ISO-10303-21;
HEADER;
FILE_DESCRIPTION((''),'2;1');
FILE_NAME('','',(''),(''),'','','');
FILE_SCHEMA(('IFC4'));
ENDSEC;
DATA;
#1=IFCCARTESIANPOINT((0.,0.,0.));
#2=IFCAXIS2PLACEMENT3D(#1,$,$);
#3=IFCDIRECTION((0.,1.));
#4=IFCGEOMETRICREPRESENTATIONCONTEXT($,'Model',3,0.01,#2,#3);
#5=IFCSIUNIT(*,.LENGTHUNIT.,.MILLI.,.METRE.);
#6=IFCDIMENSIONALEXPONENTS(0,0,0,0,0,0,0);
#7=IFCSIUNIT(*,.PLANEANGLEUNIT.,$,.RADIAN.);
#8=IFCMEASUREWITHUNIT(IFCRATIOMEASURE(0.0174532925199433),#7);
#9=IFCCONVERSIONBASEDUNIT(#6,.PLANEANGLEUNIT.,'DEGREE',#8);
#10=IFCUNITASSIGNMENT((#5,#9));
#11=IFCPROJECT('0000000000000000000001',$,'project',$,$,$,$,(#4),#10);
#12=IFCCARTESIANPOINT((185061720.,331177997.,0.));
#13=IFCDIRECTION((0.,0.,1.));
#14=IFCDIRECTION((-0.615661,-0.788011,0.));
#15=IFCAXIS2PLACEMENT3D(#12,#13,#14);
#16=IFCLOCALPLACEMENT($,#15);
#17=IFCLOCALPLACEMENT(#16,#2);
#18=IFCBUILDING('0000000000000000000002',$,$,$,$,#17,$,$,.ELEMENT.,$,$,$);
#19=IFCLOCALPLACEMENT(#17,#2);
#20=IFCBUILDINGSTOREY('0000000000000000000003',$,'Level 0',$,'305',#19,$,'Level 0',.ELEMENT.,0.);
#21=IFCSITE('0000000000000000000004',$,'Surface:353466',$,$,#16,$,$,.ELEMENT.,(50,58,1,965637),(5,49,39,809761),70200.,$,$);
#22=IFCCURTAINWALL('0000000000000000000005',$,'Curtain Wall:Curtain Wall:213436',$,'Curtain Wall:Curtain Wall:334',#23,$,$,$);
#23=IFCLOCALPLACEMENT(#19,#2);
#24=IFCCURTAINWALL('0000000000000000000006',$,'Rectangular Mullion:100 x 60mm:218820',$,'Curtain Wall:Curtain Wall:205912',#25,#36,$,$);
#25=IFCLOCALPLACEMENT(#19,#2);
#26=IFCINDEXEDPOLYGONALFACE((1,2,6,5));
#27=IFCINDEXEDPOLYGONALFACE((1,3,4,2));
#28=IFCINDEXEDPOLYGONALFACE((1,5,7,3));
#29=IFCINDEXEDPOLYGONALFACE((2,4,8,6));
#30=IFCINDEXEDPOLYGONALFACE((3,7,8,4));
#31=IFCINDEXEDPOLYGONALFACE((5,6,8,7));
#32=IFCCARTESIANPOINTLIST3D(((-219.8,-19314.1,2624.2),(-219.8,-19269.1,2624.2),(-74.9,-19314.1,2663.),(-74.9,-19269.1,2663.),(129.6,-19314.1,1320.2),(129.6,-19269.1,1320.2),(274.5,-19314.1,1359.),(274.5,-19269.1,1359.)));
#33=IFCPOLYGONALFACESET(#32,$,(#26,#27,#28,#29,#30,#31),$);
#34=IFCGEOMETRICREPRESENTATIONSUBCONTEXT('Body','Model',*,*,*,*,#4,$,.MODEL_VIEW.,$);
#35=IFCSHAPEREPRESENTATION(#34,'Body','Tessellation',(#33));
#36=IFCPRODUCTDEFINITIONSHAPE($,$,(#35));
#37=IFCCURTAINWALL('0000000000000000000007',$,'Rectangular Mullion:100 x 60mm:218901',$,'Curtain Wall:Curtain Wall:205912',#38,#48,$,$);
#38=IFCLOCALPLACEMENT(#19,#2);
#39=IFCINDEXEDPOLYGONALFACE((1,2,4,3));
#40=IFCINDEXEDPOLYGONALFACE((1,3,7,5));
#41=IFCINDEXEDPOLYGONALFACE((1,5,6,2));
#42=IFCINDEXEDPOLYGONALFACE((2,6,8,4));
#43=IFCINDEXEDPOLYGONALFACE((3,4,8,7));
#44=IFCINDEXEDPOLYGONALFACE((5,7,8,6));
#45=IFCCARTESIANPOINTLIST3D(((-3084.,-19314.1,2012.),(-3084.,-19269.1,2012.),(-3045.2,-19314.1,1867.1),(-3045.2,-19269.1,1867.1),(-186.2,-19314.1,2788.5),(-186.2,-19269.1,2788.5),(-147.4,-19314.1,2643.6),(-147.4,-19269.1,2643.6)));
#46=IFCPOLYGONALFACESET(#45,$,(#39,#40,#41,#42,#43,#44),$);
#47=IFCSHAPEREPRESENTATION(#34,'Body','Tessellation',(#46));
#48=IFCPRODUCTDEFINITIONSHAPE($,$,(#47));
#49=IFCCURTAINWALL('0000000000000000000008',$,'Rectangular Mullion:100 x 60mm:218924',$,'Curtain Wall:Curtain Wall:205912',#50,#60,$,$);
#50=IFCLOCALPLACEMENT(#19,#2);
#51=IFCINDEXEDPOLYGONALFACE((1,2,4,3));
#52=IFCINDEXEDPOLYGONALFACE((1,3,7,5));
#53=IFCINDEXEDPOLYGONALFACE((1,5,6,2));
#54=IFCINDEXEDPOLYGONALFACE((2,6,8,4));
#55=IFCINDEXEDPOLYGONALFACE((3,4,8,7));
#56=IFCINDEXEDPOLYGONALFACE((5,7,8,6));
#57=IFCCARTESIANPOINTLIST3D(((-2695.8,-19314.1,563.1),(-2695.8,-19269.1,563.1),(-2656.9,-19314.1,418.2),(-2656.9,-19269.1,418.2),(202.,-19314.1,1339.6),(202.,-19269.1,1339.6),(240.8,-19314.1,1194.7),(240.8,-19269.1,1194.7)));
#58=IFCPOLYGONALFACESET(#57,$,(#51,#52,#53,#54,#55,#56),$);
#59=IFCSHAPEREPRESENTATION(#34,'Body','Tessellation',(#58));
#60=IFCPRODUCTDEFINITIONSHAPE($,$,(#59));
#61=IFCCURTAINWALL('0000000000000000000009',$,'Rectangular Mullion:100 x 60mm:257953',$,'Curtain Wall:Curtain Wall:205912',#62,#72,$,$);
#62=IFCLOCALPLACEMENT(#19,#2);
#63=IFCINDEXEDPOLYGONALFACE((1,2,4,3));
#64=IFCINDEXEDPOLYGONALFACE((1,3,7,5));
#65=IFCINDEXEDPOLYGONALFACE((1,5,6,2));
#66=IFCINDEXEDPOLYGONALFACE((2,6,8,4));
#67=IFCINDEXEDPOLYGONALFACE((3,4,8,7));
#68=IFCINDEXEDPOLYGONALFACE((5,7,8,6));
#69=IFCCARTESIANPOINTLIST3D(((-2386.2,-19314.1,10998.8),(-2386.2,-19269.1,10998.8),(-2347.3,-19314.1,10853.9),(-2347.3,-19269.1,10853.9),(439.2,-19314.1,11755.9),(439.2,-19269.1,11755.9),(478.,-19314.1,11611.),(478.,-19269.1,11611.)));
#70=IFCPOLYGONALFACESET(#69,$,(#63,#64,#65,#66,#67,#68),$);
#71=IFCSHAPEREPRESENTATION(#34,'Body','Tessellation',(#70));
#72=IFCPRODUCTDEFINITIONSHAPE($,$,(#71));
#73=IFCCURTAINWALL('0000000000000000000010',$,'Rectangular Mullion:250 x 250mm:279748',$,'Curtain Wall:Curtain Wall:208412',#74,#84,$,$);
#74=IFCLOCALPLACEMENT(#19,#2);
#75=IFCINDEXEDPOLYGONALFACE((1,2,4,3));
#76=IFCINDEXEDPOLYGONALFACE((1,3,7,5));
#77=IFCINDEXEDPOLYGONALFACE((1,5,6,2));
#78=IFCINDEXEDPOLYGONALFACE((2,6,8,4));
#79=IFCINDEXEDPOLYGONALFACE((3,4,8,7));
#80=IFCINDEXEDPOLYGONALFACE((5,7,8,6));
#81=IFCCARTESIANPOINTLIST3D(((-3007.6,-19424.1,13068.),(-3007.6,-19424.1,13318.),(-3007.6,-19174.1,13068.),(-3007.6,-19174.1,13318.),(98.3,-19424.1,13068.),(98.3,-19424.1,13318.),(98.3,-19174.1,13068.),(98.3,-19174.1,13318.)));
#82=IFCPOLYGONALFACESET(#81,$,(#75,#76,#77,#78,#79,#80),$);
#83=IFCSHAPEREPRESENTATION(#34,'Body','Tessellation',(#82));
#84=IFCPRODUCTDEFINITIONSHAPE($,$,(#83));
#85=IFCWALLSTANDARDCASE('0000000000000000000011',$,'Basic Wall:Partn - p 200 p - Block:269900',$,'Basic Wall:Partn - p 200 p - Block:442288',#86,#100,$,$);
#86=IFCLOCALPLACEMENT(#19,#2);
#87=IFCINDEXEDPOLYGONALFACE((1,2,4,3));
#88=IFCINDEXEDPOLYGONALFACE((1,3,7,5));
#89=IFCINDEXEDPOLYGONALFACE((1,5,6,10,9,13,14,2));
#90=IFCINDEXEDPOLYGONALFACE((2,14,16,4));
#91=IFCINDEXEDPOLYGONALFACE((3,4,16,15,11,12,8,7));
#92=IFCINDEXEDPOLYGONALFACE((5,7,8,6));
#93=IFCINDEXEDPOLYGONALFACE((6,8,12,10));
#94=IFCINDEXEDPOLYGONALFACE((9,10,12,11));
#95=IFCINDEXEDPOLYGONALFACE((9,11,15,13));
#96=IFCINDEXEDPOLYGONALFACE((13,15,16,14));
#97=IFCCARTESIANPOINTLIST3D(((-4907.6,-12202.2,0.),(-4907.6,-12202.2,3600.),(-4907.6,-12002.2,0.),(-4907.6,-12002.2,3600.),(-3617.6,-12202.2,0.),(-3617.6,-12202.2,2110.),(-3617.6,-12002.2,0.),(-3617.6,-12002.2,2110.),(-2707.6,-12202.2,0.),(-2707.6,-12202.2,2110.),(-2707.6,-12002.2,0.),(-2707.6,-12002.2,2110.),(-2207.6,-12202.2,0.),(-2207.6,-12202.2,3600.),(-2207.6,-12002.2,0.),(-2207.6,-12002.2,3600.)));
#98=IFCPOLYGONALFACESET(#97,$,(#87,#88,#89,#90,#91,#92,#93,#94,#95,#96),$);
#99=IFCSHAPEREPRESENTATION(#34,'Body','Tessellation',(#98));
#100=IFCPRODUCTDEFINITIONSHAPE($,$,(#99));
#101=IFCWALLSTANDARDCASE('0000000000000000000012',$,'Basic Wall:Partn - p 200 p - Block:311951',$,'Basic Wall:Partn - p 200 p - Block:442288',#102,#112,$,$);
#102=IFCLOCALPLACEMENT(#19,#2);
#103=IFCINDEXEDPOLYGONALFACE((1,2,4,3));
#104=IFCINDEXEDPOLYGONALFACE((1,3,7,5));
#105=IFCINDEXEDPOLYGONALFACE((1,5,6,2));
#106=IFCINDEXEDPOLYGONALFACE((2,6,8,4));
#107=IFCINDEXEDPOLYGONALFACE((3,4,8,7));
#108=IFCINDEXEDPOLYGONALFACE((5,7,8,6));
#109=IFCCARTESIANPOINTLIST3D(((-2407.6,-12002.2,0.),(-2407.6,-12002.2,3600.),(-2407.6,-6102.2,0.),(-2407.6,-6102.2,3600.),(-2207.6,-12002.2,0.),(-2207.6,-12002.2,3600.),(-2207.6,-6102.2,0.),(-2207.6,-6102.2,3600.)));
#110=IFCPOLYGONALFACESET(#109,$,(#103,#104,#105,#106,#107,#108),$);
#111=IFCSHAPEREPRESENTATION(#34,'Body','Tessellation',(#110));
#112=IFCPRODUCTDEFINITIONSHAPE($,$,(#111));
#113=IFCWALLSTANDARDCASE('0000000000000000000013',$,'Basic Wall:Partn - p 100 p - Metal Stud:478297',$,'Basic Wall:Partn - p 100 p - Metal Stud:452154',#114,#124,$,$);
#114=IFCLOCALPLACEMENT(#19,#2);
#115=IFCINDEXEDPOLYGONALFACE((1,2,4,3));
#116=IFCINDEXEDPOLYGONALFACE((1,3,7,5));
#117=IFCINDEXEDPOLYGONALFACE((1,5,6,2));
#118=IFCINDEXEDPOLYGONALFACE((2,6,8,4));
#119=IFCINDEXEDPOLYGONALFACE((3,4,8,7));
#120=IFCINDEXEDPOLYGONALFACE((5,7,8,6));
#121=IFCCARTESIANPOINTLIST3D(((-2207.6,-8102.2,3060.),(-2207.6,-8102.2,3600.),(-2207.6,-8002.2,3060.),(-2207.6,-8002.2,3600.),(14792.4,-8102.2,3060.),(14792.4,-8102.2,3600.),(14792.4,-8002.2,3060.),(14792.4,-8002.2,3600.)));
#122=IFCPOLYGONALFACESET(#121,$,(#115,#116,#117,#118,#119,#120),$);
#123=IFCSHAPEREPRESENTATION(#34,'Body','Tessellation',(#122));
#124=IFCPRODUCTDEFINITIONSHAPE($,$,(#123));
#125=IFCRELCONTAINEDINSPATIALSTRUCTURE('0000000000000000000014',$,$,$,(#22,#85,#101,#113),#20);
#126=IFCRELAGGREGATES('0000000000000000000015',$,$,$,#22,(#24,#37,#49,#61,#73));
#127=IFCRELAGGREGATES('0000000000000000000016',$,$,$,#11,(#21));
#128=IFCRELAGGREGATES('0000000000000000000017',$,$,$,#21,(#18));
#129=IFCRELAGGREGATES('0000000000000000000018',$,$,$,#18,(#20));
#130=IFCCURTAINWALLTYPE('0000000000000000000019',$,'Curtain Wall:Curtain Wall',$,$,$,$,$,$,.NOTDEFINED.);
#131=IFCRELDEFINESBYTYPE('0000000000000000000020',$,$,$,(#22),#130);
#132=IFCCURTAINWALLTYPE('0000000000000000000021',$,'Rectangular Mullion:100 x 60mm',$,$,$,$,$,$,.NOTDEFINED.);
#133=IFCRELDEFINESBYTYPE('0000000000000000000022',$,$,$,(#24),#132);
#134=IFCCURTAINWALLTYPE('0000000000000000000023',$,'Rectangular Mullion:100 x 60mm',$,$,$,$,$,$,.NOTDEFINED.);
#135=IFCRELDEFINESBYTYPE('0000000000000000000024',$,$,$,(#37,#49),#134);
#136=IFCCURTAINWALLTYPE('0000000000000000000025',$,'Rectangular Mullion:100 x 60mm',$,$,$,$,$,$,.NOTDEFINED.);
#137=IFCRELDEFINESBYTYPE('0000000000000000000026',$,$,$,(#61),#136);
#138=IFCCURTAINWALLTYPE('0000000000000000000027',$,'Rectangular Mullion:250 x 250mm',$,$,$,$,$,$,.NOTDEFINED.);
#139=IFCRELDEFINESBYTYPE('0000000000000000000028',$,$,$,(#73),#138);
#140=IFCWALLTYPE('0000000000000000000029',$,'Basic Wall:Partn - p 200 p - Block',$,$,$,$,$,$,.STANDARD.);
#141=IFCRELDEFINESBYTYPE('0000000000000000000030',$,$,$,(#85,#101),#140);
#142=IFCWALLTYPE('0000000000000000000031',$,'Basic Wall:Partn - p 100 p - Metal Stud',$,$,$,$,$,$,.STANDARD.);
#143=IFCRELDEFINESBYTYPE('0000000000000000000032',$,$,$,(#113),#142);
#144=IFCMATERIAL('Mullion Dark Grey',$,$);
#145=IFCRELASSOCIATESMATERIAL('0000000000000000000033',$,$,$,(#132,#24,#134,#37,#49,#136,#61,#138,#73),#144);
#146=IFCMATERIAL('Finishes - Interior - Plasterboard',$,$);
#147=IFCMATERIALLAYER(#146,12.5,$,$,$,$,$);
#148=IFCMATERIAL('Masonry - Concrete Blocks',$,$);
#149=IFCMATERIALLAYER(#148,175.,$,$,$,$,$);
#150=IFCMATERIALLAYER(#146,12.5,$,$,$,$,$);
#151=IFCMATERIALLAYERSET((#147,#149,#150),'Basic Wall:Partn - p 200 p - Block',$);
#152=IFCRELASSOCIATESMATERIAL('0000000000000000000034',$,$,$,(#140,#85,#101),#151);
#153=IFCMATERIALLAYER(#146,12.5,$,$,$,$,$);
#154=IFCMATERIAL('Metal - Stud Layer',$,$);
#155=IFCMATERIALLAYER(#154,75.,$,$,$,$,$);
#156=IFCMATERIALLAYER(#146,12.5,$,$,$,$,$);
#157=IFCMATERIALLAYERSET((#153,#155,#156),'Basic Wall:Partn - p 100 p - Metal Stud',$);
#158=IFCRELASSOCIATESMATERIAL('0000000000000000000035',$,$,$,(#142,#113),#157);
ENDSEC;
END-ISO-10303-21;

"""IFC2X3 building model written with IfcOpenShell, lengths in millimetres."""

from ifc_helpers import new_model, entity, si_unit, converted_unit, direction, frame, frame_2d, origin, origin_2d_with_axis, place, context, subcontext, project, spatial, polyline, rectangle, extrude, clip, bounded_halfspace, source, transform, mapped, material, layer, layer_set, layer_usage, type_object, type_shapes, element, aggregate, save


model = new_model("IFC2X3")

# Units and contexts
model_context = context("Model", 3, precision=0.01, world=origin(), true_north=direction((0.0, 1.0)))
body_context = subcontext(model_context, "Body", "Model", "MODEL_VIEW")
ifc_project = project(units=[si_unit("LENGTHUNIT", "METRE", prefix="MILLI"), converted_unit("PLANEANGLEUNIT", "DEGREE", entity("IfcRatioMeasure", 0.0174532925199433), si_unit("PLANEANGLEUNIT", "RADIAN"), dimensions=[0, 0, 0, 0, 0, 0, 0])], contexts=[model_context])

# Site, building, storey
site_placement = place(None, frame((185061720.0, 331177997.0, 0.0), z_axis=(0.0, 0.0, 1.0), x_axis=(-0.615661, -0.788011, 0.0)))
site = spatial("IfcSite", under=ifc_project, at=site_placement, Name="Surface:353466", CompositionType="ELEMENT", RefLatitude=(50, 58, 1, 965637), RefLongitude=(5, 49, 39, 809761), RefElevation=70200.0)
building_placement = place(site_placement, origin())
building = spatial("IfcBuilding", under=site, at=building_placement, CompositionType="ELEMENT")
storey_placement = place(building_placement, origin())
storey = spatial("IfcBuildingStorey", under=building, at=storey_placement, Name="Level 0", ObjectType="305", LongName="Level 0", CompositionType="ELEMENT", Elevation=0.0)

# Shared definitions
ifc_material_1 = material(Name="Masonry - Concrete Blocks")
ifc_material_2 = material(Name="Finishes - Interior - Plasterboard")

# Curtain walls
curtain_wall_type_1 = type_object("IfcCurtainWallType", Name="Curtain Wall:Curtain Wall", PredefinedType="NOTDEFINED")
curtain_wall_1_placement = place(storey_placement, origin())
curtain_wall_1 = element("IfcCurtainWall", 1, at=curtain_wall_1_placement, inside=storey, type_object=curtain_wall_type_1, Name="Curtain Wall:Curtain Wall:213436", ObjectType="Curtain Wall:Curtain Wall:334")
ifc_material_3 = material(Name="Mullion Dark Grey")
curtain_wall_type_2 = type_object("IfcCurtainWallType", Name="Rectangular Mullion:100 x 60mm", PredefinedType="NOTDEFINED", material=ifc_material_3)
shared_shape_1 = source(origin(), body_context, "Body", "SweptSolid", [
    extrude(rectangle(XDim=150.0, YDim=45.0, at=frame_2d((0.0, 0.0), x_axis=(1.0, 0.0))), frame((0.0, -7.5, -1350.0)), (0.0, 0.0, 1.0), 1350.0),
])
type_shapes(curtain_wall_type_2, [shared_shape_1])
curtain_wall_2_placement = place(storey_placement, frame((202.0, -19299.1, 1339.6), z_axis=(0.258819, 0.0, -0.965926), x_axis=(0.965926, 0.0, 0.258819)))
curtain_wall_2 = element("IfcCurtainWall", 2, at=curtain_wall_2_placement, type_object=curtain_wall_type_2, material=ifc_material_3, Name="Rectangular Mullion:100 x 60mm:218820", ObjectType="Curtain Wall:Curtain Wall:205912", context=body_context, shape_type="MappedRepresentation", body=[
    mapped(shared_shape_1, transform((0.0, 0.0, 0.0), scale=1.0)),
])
curtain_wall_type_3 = type_object("IfcCurtainWallType", Name="Rectangular Mullion:100 x 60mm", PredefinedType="NOTDEFINED", material=ifc_material_3)
shared_shape_2 = source(origin(), body_context, "Body", "SweptSolid", [
    extrude(rectangle(XDim=150.0, YDim=45.0, at=frame_2d((0.0, 0.0), x_axis=(1.0, 0.0))), frame((0.0, -7.5, -3000.0)), (0.0, 0.0, 1.0), 3000.0),
])
type_shapes(curtain_wall_type_3, [shared_shape_2])
curtain_wall_3_placement = place(storey_placement, frame((-166.8, -19299.1, 2716.0), z_axis=(0.965926, 0.0, 0.258819), x_axis=(-0.258819, 0.0, 0.965926)))
curtain_wall_3 = element("IfcCurtainWall", 3, at=curtain_wall_3_placement, type_object=curtain_wall_type_3, material=ifc_material_3, Name="Rectangular Mullion:100 x 60mm:218901", ObjectType="Curtain Wall:Curtain Wall:205912", context=body_context, shape_type="MappedRepresentation", body=[
    mapped(shared_shape_2, transform((0.0, 0.0, 0.0), scale=1.0)),
])
curtain_wall_4_placement = place(storey_placement, frame((221.4, -19299.1, 1267.1), z_axis=(0.965926, 0.0, 0.258819), x_axis=(-0.258819, 0.0, 0.965926)))
curtain_wall_4 = element("IfcCurtainWall", 4, at=curtain_wall_4_placement, type_object=curtain_wall_type_3, material=ifc_material_3, Name="Rectangular Mullion:100 x 60mm:218924", ObjectType="Curtain Wall:Curtain Wall:205912", context=body_context, shape_type="MappedRepresentation", body=[
    mapped(shared_shape_2, transform((0.0, 0.0, 0.0), scale=1.0)),
])
curtain_wall_type_4 = type_object("IfcCurtainWallType", Name="Rectangular Mullion:100 x 60mm", PredefinedType="NOTDEFINED", material=ifc_material_3)
shared_shape_3 = source(origin(), body_context, "Body", "SweptSolid", [
    extrude(rectangle(XDim=150.0, YDim=45.0, at=frame_2d((0.0, 0.0), x_axis=(1.0, 0.0))), frame((0.0, -7.5, -2925.0)), (0.0, 0.0, 1.0), 2925.0),
])
type_shapes(curtain_wall_type_4, [shared_shape_3])
curtain_wall_5_placement = place(storey_placement, frame((458.6, -19299.1, 11683.4), z_axis=(0.965926, 0.0, 0.258819), x_axis=(-0.258819, 0.0, 0.965926)))
curtain_wall_5 = element("IfcCurtainWall", 5, at=curtain_wall_5_placement, type_object=curtain_wall_type_4, material=ifc_material_3, Name="Rectangular Mullion:100 x 60mm:257953", ObjectType="Curtain Wall:Curtain Wall:205912", context=body_context, shape_type="MappedRepresentation", body=[
    mapped(shared_shape_3, transform((0.0, 0.0, 0.0), scale=1.0)),
])
curtain_wall_type_5 = type_object("IfcCurtainWallType", Name="Rectangular Mullion:250 x 250mm", PredefinedType="NOTDEFINED", material=ifc_material_3)
shared_shape_4 = source(origin(), body_context, "Body", "SweptSolid", [
    extrude(rectangle(XDim=250.0, YDim=250.0, at=origin_2d_with_axis()), frame((-125.0, 0.0, -3105.8), z_axis=(0.0, 0.0, 1.0), x_axis=(-1.0, 0.0, 0.0)), (0.0, 0.0, 1.0), 3105.8),
])
type_shapes(curtain_wall_type_5, [shared_shape_4])
curtain_wall_6_placement = place(storey_placement, frame((98.3, -19299.1, 13318.0), z_axis=(1.0, 0.0, 0.0), x_axis=(0.0, 0.0, 1.0)))
curtain_wall_6 = element("IfcCurtainWall", 6, at=curtain_wall_6_placement, type_object=curtain_wall_type_5, material=ifc_material_3, Name="Rectangular Mullion:250 x 250mm:279748", ObjectType="Curtain Wall:Curtain Wall:208412", context=body_context, shape_type="MappedRepresentation", body=[
    mapped(shared_shape_4, transform((0.0, 0.0, 0.0), scale=1.0)),
])
aggregate(curtain_wall_1, [curtain_wall_2, curtain_wall_3, curtain_wall_4, curtain_wall_5, curtain_wall_6])

# Wall, openings
ifc_layer_1 = layer(ifc_material_2, 12.5)
ifc_layer_2 = layer(ifc_material_1, 175.0)
ifc_layer_3 = layer(ifc_material_2, 12.5)
ifc_layer_set_1 = layer_set([ifc_layer_1, ifc_layer_2, ifc_layer_3], Name="Basic Wall:Partn - p 200 p - Block")
ifc_layer_usage_1 = layer_usage(ifc_layer_set_1, "AXIS2", "POSITIVE", -100.0)
wall_type_1 = type_object("IfcWallType", Name="Basic Wall:Partn - p 200 p - Block", PredefinedType="STANDARD", material=ifc_layer_set_1)
wall_1_placement = place(storey_placement, frame((-4907.6, -12102.2, 0.0)))
wall_1 = element("IfcWallStandardCase", 7, at=wall_1_placement, inside=storey, type_object=wall_type_1, material=ifc_layer_usage_1, Name="Basic Wall:Partn - p 200 p - Block:269900", ObjectType="Basic Wall:Partn - p 200 p - Block:442288", context=body_context, shape_type="Clipping", body=[
    clip(extrude(rectangle(XDim=2700.0, YDim=200.0, at=frame_2d((1350.0, 0.0), x_axis=(-1.0, 0.0))), origin(), (0.0, 0.0, 1.0), 3600.0), bounded_halfspace(frame((0.0, -100.0, 3600.0), z_axis=(0.0, 0.0, -1.0), x_axis=(1.0, 0.0, 0.0)), True, frame((0.0, -100.0, 3600.0)), polyline([(0.0, 0.0), (200.0, 0.0), (400.0, 0.0), (2700.0, 0.0), (2700.0, 200.0), (2500.0, 200.0), (0.0, 200.0), (0.0, 0.0)]))),
])
opening_1_placement = place(wall_1_placement, frame((1290.0, -1624.0, 0.0)))
element("IfcOpeningElement", 8, at=opening_1_placement, cuts=wall_1, ObjectType="Opening", context=body_context, shape_type="SweptSolid", body=[
    extrude(rectangle(XDim=2110.0, YDim=910.0, at=frame_2d((0.0, 0.0), x_axis=(0.0, 1.0))), frame((455.0, 0.0, 1055.0), z_axis=(0.0, 1.0, 0.0), x_axis=(-1.0, 0.0, 0.0)), (0.0, 0.0, 1.0), 3048.0),
])
opening_2_placement = place(wall_1_placement, frame((1290.0, -100.0, 0.0)))
element("IfcOpeningElement", 9, at=opening_2_placement, cuts=wall_1, ObjectType="Opening", context=body_context, shape_type="SweptSolid", body=[
    extrude(rectangle(XDim=2110.0, YDim=910.0, at=frame_2d((1055.0, 455.0), x_axis=(1.0, 0.0))), frame((0.0, 0.0, 0.0), z_axis=(0.0, 1.0, 0.0), x_axis=(0.0, 0.0, 1.0)), (0.0, 0.0, 1.0), 200.0),
])

# Wall
ifc_layer_usage_2 = layer_usage(ifc_layer_set_1, "AXIS2", "NEGATIVE", 100.0)
wall_2_placement = place(storey_placement, frame((-2307.6, -6102.2, 0.0), z_axis=(0.0, 0.0, 1.0), x_axis=(0.0, -1.0, 0.0)))
element("IfcWallStandardCase", 10, at=wall_2_placement, inside=storey, type_object=wall_type_1, material=ifc_layer_usage_2, Name="Basic Wall:Partn - p 200 p - Block:311951", ObjectType="Basic Wall:Partn - p 200 p - Block:442288", context=body_context, shape_type="Clipping", body=[
    clip(extrude(rectangle(XDim=5900.0, YDim=200.0, at=frame_2d((2950.0, 0.0), x_axis=(-1.0, 0.0))), origin(), (0.0, 0.0, 1.0), 3600.0), bounded_halfspace(frame((0.0, -100.0, 3600.0), z_axis=(0.0, 0.0, -1.0), x_axis=(0.0, 1.0, 0.0)), True, frame((0.0, -100.0, 3600.0)), polyline([(0.0, 0.0), (5900.0, 0.0), (5900.0, 200.0), (0.0, 200.0), (0.0, 0.0)]))),
])

# Wall
ifc_layer_4 = layer(ifc_material_2, 12.5)
ifc_material_4 = material(Name="Metal - Stud Layer")
ifc_layer_5 = layer(ifc_material_4, 75.0)
ifc_layer_6 = layer(ifc_material_2, 12.5)
ifc_layer_set_2 = layer_set([ifc_layer_4, ifc_layer_5, ifc_layer_6], Name="Basic Wall:Partn - p 100 p - Metal Stud")
ifc_layer_usage_3 = layer_usage(ifc_layer_set_2, "AXIS2", "NEGATIVE", 50.0)
wall_type_2 = type_object("IfcWallType", Name="Basic Wall:Partn - p 100 p - Metal Stud", PredefinedType="STANDARD", material=ifc_layer_set_2)
wall_3_placement = place(storey_placement, frame((-2207.6, -8052.2, 3060.0)))
element("IfcWallStandardCase", 11, at=wall_3_placement, inside=storey, type_object=wall_type_2, material=ifc_layer_usage_3, Name="Basic Wall:Partn - p 100 p - Metal Stud:478297", ObjectType="Basic Wall:Partn - p 100 p - Metal Stud:452154", context=body_context, shape_type="SweptSolid", body=[
    extrude(rectangle(XDim=17000.0, YDim=100.0, at=frame_2d((8500.0, 0.0), x_axis=(-1.0, 0.0))), origin(), (0.0, 0.0, 1.0), 540.0),
])

save(model, "model.ifc")
